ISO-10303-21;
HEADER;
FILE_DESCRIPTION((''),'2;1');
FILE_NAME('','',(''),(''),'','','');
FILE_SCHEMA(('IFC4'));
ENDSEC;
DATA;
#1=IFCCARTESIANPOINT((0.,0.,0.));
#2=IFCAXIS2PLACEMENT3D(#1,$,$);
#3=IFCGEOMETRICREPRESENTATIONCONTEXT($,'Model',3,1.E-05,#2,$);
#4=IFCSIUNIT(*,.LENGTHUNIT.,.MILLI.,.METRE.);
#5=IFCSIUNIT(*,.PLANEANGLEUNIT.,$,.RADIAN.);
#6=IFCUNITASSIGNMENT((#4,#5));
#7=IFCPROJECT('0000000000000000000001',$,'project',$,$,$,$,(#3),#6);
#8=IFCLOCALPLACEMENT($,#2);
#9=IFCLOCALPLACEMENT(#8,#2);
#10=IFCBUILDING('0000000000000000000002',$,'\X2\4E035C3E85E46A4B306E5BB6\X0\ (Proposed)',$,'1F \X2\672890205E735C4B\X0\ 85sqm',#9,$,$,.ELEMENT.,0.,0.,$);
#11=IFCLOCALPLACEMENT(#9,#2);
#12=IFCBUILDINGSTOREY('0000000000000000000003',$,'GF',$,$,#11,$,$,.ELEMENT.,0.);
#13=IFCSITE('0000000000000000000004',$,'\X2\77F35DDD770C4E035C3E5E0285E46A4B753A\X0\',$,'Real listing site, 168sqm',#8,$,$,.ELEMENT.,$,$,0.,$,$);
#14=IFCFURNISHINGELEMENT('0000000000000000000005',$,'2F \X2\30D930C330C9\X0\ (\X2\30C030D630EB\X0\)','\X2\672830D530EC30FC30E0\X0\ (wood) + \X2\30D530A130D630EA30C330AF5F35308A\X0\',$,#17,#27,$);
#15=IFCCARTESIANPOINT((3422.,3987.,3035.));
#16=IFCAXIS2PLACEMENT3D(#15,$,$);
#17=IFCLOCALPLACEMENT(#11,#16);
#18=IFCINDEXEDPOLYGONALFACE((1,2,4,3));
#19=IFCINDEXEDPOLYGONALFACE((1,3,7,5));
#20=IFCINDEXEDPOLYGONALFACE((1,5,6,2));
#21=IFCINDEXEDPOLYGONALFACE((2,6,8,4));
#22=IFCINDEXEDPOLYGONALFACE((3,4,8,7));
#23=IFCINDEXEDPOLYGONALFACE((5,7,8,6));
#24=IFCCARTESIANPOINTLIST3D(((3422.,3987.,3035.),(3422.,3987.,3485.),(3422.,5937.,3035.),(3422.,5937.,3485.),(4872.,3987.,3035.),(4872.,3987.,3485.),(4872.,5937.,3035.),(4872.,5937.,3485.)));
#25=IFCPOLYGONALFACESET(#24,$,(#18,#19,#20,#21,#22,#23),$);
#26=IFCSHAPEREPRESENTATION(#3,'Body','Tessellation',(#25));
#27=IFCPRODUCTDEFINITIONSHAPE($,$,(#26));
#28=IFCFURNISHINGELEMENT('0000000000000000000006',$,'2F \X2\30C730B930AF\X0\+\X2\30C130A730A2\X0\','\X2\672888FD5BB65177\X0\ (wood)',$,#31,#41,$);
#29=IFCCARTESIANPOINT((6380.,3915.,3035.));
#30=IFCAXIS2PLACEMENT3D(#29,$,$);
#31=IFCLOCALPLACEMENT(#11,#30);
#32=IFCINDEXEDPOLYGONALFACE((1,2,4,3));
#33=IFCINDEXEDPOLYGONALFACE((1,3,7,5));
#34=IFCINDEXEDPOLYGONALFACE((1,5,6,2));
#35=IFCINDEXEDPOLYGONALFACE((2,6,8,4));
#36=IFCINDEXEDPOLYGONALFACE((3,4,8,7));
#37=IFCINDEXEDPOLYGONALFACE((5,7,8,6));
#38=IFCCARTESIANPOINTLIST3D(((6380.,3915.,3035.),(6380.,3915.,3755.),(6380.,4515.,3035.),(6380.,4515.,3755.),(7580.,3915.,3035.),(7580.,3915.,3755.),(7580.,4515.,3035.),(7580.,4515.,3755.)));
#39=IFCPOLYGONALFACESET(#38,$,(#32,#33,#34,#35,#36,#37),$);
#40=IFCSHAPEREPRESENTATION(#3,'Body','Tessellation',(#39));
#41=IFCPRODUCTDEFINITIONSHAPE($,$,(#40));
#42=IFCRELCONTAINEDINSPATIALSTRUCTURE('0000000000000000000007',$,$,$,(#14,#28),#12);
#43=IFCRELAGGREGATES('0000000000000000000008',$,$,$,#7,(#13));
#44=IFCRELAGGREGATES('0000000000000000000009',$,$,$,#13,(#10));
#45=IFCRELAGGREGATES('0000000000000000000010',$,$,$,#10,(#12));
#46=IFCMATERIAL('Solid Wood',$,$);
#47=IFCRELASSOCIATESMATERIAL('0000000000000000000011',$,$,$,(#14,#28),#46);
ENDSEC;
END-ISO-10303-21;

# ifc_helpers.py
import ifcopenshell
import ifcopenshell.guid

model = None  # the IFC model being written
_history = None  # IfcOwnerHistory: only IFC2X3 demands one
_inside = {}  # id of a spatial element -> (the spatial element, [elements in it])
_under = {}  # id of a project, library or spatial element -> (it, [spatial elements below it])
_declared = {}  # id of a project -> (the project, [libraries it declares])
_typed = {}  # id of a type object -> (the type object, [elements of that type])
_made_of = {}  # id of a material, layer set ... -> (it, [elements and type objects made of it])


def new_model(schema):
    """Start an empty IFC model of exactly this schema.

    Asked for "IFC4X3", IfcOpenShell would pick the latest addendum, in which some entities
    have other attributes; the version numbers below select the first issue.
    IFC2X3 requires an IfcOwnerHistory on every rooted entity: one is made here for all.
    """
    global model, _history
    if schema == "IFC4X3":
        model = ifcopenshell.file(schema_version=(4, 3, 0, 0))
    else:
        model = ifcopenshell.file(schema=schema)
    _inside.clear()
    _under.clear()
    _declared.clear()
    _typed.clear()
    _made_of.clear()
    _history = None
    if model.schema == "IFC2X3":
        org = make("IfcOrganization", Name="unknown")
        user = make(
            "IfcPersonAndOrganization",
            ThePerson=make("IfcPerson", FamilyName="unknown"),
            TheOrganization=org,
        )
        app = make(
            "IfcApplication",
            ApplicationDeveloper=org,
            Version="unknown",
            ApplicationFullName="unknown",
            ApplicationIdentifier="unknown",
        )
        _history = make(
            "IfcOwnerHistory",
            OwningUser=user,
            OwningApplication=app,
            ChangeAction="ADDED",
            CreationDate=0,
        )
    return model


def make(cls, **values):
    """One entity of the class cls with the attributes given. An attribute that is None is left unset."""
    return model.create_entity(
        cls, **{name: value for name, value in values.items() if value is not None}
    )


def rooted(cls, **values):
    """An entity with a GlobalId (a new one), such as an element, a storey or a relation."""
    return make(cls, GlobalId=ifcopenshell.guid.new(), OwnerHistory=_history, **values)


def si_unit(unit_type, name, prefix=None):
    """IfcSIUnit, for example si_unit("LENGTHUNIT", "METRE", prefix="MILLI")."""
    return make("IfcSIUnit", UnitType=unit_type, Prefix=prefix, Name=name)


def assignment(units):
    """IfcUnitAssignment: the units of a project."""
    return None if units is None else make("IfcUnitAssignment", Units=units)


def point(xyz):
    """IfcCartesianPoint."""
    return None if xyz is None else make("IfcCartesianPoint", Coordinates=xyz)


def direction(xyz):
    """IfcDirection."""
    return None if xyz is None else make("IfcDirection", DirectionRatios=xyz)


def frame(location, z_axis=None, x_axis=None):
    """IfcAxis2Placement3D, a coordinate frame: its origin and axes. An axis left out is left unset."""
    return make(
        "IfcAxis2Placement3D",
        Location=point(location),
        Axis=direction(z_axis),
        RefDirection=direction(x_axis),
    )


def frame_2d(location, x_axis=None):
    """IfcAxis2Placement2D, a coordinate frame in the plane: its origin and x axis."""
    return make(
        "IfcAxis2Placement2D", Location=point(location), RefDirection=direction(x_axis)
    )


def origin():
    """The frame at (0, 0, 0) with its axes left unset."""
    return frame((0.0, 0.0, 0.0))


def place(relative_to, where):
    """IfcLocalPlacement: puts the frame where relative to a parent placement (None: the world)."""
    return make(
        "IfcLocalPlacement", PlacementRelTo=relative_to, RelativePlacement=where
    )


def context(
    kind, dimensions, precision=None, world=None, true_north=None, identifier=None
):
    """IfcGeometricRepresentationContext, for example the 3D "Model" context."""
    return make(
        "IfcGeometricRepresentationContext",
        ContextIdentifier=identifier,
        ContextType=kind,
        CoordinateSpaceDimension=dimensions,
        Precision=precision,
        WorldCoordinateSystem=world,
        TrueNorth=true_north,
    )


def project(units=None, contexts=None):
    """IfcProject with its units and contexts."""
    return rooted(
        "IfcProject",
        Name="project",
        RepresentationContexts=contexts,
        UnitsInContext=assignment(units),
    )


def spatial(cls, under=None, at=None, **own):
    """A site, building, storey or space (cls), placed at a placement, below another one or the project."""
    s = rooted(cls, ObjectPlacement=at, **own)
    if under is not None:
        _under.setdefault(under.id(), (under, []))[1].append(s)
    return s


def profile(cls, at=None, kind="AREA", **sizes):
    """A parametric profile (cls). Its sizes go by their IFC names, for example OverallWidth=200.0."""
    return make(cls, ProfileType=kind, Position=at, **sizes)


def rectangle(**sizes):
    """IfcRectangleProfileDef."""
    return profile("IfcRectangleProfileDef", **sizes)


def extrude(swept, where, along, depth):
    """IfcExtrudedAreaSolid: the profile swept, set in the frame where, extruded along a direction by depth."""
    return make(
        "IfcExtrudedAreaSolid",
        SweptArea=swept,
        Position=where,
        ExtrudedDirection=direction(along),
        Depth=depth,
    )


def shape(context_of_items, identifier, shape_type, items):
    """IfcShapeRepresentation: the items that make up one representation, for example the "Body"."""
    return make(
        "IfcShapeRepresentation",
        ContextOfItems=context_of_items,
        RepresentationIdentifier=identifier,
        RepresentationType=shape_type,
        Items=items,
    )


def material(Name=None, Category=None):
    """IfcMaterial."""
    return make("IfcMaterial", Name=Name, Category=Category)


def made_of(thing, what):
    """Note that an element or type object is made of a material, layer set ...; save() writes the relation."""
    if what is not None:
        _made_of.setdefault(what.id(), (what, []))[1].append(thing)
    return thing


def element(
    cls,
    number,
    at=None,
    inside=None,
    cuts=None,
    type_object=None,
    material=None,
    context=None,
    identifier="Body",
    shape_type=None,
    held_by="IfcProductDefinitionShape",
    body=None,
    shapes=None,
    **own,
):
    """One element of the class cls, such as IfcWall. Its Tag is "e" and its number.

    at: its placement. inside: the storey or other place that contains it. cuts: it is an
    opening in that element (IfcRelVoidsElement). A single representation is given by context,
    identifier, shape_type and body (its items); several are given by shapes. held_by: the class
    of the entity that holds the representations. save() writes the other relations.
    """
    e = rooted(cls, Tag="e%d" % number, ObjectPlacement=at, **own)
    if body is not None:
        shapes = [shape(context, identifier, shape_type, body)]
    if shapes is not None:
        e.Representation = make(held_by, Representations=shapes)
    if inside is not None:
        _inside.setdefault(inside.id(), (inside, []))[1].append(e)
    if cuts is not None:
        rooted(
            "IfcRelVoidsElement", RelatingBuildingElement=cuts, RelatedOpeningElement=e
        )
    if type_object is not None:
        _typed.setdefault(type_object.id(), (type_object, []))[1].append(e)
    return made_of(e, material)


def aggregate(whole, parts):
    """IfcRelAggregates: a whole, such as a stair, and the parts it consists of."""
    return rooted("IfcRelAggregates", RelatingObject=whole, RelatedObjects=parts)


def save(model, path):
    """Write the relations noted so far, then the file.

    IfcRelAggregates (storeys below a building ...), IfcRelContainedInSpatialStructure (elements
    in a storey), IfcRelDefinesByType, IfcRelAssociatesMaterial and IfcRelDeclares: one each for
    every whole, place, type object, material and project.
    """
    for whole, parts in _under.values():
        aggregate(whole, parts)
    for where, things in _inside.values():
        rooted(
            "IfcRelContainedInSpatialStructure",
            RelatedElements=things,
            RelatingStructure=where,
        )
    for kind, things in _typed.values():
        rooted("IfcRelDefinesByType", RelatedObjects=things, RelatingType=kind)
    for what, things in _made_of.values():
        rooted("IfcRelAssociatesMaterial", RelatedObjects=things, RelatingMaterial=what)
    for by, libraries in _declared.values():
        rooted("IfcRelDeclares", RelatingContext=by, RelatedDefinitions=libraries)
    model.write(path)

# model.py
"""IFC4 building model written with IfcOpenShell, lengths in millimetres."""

from ifc_helpers import new_model, si_unit, frame, frame_2d, origin, place, context, project, spatial, rectangle, extrude, material, element, save


model = new_model("IFC4")

# Units and contexts
model_context = context("Model", 3, precision=1e-05, world=origin())
ifc_project = project(units=[si_unit("LENGTHUNIT", "METRE", prefix="MILLI"), si_unit("PLANEANGLEUNIT", "RADIAN")], contexts=[model_context])

# Site, building, storey
site_placement = place(None, origin())
site = spatial("IfcSite", under=ifc_project, at=site_placement, Name="石川県七尾市藤橋町", ObjectType="Real listing site, 168sqm", CompositionType="ELEMENT", RefElevation=0.0)
building_placement = place(site_placement, origin())
building = spatial("IfcBuilding", under=site, at=building_placement, Name="七尾藤橋の家 (Proposed)", ObjectType="1F 木造平屋 85sqm", CompositionType="ELEMENT", ElevationOfRefHeight=0.0, ElevationOfTerrain=0.0)
storey_placement = place(building_placement, origin())
storey = spatial("IfcBuildingStorey", under=building, at=storey_placement, Name="GF", CompositionType="ELEMENT", Elevation=0.0)

# Shared definitions
ifc_material_1 = material(Name="Solid Wood")

# Furnishing elements
furnishing_1_placement = place(storey_placement, frame((3422.0, 3987.0, 3035.0)))
element("IfcFurnishingElement", 1, at=furnishing_1_placement, inside=storey, material=ifc_material_1, Name="2F ベッド (ダブル)", Description="木フレーム (wood) + ファブリック張り", context=model_context, shape_type="SweptSolid", body=[
    extrude(rectangle(XDim=1450.0, YDim=1950.0, at=frame_2d((725.0, 975.0))), frame((3422.0, 3987.0, 3035.0)), (0.0, 0.0, 1.0), 450.0),
])
furnishing_2_placement = place(storey_placement, frame((6380.0, 3915.0, 3035.0)))
element("IfcFurnishingElement", 2, at=furnishing_2_placement, inside=storey, material=ifc_material_1, Name="2F デスク+チェア", Description="木製家具 (wood)", context=model_context, shape_type="SweptSolid", body=[
    extrude(rectangle(XDim=1200.0, YDim=600.0, at=frame_2d((600.0, 300.0))), frame((6380.0, 3915.0, 3035.0)), (0.0, 0.0, 1.0), 720.0),
])

save(model, "model.ifc")
